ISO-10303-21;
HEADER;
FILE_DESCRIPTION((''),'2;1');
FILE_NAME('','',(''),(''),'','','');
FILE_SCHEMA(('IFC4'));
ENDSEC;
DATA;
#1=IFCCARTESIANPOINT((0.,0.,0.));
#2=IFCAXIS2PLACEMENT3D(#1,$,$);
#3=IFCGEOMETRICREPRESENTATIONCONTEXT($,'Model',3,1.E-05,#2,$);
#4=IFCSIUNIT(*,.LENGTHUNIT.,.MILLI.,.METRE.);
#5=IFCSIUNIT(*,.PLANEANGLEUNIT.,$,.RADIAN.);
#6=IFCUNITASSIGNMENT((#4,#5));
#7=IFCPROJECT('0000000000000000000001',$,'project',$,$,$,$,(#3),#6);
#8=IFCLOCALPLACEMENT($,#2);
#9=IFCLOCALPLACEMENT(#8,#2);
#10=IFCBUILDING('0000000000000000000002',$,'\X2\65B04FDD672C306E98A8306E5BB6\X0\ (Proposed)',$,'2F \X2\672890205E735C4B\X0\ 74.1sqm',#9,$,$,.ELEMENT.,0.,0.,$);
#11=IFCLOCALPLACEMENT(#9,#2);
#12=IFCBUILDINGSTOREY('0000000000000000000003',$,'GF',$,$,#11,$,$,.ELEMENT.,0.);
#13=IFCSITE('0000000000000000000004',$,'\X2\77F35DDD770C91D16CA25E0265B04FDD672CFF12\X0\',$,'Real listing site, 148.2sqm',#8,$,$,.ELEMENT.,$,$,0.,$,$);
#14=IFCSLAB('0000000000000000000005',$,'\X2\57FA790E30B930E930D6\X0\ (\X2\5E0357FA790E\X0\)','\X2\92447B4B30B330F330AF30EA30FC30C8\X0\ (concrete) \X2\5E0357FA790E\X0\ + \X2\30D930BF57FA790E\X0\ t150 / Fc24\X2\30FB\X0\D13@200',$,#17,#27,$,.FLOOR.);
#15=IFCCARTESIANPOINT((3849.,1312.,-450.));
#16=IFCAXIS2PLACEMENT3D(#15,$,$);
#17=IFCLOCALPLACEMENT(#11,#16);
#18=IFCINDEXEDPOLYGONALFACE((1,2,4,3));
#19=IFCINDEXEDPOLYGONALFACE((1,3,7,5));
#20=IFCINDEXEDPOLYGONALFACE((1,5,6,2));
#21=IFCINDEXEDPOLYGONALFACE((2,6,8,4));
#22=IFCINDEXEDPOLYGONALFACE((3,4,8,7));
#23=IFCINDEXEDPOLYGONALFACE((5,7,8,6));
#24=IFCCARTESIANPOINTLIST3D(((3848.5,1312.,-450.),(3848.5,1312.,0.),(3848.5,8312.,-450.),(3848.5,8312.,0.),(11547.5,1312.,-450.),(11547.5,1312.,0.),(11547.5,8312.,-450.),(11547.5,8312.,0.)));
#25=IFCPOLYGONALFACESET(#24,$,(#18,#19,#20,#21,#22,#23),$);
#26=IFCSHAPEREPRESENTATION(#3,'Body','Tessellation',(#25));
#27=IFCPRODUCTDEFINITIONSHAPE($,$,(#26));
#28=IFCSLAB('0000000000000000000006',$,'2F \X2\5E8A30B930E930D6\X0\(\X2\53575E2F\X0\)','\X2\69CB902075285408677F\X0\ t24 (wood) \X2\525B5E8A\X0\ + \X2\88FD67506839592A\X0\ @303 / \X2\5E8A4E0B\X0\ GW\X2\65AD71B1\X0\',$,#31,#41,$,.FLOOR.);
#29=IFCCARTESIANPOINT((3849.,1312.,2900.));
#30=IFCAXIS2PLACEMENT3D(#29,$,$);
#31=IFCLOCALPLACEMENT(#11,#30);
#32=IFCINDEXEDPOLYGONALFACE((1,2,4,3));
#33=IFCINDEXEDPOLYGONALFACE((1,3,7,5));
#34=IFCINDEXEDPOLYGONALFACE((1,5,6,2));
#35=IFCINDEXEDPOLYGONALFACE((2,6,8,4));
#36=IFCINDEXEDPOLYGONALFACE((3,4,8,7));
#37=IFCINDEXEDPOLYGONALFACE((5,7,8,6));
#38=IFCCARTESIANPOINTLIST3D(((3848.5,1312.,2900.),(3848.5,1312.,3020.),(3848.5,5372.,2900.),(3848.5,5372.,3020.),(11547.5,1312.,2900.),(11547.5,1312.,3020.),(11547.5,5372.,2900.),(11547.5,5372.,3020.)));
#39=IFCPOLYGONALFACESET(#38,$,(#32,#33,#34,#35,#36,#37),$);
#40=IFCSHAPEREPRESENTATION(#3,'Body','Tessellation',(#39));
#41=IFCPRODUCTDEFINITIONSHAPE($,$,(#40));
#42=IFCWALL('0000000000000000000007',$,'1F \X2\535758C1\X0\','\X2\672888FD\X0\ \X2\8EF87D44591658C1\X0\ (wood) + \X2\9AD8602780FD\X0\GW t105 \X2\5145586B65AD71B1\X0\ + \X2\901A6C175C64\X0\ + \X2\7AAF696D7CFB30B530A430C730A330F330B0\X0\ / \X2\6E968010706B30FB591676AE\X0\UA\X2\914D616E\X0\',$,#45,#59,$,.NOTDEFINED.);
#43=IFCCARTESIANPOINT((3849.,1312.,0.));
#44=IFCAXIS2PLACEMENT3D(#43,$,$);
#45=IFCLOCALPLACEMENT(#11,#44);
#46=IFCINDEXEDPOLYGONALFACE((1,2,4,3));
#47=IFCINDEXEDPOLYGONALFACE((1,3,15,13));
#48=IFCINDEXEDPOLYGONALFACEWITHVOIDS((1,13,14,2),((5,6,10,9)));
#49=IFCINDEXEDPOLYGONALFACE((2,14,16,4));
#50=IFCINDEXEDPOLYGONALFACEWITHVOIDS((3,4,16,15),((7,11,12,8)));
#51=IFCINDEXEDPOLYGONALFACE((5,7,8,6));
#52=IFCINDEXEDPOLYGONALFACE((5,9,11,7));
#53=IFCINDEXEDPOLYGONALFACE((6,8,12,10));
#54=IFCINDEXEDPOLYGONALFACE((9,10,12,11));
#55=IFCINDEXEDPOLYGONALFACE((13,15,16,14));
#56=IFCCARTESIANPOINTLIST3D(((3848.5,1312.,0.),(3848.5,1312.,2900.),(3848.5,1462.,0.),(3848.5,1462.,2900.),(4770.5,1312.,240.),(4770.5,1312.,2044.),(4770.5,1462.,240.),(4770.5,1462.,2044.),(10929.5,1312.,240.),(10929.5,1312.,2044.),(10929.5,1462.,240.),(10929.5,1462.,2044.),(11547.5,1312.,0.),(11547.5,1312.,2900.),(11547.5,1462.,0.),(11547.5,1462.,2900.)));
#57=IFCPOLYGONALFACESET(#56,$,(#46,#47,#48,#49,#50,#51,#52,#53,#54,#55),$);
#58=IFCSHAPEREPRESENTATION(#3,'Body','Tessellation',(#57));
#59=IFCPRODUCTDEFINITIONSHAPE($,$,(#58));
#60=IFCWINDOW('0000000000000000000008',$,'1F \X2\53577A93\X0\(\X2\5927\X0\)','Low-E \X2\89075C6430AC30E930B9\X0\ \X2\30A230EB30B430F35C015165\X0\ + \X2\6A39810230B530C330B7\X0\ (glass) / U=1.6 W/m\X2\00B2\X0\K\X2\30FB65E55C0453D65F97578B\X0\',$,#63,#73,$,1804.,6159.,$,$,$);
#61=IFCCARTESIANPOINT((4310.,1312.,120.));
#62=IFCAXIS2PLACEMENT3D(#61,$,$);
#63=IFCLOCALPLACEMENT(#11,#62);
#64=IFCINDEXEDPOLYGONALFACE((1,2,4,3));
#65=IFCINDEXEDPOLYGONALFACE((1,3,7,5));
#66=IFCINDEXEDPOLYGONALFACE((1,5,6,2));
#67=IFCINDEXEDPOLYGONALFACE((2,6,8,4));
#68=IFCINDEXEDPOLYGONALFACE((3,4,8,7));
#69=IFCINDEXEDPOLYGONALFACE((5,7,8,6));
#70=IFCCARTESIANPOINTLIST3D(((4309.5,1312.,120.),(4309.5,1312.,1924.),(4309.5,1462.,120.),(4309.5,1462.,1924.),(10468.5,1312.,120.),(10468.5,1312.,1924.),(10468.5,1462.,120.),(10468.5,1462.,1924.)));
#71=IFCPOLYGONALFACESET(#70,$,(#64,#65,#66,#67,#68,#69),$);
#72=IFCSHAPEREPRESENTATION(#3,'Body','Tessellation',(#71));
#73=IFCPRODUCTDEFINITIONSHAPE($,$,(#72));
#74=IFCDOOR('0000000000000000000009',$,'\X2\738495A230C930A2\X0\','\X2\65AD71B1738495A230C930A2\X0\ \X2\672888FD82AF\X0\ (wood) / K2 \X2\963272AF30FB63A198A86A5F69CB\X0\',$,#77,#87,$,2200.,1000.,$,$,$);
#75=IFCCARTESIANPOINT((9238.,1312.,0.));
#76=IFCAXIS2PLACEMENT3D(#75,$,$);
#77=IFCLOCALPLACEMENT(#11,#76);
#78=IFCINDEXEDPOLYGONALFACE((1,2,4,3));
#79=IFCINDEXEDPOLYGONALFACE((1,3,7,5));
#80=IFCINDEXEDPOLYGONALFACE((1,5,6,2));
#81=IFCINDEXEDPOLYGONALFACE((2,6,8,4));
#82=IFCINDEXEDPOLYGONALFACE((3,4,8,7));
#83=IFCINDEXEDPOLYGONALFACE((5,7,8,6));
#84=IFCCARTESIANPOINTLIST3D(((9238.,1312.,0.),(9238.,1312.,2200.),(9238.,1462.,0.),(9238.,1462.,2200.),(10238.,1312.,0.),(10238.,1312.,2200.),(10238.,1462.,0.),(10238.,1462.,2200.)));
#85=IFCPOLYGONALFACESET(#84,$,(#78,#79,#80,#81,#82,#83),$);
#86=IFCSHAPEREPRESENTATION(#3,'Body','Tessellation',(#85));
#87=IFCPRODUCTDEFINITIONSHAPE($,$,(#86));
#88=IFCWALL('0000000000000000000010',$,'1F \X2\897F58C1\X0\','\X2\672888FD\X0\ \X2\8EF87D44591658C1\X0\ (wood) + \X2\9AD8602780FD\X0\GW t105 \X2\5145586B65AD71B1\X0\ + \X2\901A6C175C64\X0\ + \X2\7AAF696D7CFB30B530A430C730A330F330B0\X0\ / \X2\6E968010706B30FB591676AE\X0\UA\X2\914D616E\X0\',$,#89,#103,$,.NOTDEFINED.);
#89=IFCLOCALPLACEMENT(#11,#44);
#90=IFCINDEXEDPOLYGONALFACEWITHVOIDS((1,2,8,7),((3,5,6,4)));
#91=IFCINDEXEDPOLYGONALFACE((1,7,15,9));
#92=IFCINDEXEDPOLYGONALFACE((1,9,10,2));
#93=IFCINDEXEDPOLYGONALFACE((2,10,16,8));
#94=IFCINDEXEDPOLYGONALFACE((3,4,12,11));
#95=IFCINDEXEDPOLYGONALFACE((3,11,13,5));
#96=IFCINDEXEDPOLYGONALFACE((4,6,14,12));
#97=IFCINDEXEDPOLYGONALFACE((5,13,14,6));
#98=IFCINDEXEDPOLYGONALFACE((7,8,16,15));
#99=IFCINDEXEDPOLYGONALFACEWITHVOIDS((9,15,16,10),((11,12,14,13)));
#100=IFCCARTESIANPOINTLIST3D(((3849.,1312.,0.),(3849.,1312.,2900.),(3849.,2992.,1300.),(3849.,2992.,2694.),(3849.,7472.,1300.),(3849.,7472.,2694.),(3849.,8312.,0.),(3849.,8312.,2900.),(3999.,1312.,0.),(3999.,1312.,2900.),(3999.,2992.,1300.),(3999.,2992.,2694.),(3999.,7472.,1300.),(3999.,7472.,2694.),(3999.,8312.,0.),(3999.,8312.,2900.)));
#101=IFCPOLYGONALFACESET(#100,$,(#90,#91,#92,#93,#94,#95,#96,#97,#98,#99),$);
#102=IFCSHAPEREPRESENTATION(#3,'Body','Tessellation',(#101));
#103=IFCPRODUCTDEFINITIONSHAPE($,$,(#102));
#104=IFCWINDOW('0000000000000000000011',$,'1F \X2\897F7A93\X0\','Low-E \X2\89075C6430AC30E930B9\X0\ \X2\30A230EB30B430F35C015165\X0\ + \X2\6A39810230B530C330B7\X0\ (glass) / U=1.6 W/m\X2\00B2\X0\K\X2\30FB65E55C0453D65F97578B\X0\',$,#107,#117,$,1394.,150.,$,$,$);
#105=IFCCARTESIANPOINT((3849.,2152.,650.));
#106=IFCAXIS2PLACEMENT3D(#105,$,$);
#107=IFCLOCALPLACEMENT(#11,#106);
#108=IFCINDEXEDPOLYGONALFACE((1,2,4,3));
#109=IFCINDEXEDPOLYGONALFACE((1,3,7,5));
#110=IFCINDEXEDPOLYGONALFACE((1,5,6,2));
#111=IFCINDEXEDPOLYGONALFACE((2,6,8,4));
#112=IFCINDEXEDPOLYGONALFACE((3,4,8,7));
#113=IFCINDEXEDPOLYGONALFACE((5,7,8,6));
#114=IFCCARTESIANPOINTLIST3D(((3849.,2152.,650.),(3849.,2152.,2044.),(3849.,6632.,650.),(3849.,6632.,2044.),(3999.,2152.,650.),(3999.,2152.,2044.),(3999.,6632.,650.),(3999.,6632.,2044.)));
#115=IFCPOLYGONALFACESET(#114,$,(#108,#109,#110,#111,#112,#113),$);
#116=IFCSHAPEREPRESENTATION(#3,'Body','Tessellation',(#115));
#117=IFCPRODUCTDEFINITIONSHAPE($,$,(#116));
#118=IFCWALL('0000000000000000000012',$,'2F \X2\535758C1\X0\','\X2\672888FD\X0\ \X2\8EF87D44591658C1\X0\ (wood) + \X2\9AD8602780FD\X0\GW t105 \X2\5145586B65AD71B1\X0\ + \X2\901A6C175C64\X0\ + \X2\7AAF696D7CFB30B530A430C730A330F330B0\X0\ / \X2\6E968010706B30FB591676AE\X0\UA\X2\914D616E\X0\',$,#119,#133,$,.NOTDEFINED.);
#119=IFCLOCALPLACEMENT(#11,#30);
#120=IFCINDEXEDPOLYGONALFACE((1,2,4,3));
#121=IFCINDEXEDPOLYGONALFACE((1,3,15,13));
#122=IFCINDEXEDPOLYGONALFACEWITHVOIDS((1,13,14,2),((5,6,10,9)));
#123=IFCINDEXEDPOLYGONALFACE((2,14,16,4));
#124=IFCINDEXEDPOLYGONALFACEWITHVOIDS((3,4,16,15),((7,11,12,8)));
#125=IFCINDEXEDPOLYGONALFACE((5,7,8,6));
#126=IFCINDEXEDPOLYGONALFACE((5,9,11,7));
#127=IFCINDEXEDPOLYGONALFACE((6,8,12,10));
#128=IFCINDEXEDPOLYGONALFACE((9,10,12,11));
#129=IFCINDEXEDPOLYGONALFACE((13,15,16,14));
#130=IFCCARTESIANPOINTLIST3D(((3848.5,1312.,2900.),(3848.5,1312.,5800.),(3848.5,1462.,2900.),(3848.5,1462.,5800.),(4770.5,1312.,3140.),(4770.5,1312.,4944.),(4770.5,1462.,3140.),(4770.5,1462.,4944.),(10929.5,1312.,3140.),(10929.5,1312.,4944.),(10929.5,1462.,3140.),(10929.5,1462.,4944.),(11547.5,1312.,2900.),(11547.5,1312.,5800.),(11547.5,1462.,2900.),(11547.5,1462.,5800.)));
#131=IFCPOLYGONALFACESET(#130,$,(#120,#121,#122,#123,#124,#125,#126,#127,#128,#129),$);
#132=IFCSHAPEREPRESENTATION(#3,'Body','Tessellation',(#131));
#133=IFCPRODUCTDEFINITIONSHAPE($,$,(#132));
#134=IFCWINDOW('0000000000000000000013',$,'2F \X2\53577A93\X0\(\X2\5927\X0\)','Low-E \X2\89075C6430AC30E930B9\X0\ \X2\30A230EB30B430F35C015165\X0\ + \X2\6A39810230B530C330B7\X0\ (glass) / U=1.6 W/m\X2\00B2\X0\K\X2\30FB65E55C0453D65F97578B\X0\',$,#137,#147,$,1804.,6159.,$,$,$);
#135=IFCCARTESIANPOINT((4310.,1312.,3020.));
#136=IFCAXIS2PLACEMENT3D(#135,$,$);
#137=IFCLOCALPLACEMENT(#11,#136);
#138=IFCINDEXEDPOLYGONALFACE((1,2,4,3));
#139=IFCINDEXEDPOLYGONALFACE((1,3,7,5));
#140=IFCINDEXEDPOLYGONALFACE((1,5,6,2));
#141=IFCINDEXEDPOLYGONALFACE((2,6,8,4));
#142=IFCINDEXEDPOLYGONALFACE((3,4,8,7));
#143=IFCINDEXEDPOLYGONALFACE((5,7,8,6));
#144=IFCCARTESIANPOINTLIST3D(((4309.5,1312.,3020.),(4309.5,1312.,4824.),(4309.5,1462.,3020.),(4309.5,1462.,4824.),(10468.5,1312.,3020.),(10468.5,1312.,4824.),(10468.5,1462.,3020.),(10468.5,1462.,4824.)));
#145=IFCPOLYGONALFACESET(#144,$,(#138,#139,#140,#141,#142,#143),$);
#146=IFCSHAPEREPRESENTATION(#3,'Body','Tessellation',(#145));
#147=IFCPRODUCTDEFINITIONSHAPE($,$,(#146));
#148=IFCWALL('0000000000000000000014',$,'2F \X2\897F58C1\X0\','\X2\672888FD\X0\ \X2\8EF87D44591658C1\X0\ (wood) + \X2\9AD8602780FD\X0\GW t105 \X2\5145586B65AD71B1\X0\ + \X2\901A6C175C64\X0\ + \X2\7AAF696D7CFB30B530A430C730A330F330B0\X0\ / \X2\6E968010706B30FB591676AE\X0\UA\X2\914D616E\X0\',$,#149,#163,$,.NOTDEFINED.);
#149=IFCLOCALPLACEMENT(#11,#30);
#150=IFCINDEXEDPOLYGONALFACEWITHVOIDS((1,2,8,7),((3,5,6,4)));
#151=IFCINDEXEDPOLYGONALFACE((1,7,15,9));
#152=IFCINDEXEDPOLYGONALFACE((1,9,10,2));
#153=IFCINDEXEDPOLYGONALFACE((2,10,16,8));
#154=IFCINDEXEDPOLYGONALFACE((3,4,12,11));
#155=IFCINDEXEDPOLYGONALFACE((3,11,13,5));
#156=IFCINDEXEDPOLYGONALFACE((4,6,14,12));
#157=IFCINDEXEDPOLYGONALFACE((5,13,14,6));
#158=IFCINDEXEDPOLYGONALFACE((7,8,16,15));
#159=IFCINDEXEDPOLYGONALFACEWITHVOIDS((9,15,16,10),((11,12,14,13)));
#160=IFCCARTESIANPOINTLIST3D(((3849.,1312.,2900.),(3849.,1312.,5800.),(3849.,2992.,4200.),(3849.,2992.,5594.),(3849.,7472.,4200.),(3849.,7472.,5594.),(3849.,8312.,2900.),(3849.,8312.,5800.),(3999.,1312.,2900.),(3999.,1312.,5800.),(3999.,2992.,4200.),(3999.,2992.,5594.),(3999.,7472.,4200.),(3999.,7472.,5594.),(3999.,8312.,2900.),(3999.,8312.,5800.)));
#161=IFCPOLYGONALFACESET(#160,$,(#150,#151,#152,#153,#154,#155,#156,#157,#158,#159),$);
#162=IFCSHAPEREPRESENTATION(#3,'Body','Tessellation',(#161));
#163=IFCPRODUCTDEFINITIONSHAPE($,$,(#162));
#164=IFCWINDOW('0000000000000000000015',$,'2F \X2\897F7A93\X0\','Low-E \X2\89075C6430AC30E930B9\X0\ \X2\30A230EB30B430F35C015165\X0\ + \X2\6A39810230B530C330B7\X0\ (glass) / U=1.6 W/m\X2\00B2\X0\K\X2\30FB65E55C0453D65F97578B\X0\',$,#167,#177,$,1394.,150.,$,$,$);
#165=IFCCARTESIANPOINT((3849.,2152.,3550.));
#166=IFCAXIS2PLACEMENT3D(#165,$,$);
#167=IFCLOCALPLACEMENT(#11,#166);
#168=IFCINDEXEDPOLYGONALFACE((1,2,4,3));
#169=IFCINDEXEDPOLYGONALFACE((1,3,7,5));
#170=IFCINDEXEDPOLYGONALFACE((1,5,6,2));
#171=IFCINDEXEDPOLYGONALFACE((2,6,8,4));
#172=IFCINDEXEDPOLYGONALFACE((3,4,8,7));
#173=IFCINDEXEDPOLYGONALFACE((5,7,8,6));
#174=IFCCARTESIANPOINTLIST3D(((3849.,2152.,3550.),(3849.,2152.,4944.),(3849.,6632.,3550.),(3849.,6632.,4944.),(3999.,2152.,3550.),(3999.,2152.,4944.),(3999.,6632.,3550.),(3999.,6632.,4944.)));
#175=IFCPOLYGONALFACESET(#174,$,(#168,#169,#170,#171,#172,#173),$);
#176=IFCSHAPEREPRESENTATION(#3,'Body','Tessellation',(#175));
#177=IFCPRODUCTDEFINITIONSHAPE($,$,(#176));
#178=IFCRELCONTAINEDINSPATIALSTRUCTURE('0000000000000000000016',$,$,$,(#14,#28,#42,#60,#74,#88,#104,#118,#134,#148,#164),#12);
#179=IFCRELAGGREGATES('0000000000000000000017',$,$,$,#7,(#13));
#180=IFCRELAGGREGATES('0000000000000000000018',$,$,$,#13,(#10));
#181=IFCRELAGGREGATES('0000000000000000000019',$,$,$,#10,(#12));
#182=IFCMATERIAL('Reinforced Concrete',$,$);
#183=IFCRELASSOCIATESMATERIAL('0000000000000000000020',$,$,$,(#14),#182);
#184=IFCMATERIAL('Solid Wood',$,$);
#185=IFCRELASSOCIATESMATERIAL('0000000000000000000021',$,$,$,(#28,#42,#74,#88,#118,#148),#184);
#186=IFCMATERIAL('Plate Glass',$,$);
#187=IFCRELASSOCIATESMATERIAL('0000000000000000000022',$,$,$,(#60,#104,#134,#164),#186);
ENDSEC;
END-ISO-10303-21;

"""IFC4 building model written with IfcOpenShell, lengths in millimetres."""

from ifc_helpers import new_model, si_unit, frame, frame_2d, origin, place, context, project, spatial, rectangle, extrude, material, element, fill, save


model = new_model("IFC4")

# Units and contexts
model_context = context("Model", 3, precision=1e-05, world=origin())
ifc_project = project(units=[si_unit("LENGTHUNIT", "METRE", prefix="MILLI"), si_unit("PLANEANGLEUNIT", "RADIAN")], contexts=[model_context])

# Site, building, storey
site_placement = place(None, origin())
site = spatial("IfcSite", under=ifc_project, at=site_placement, Name="石川県金沢市新保本２", ObjectType="Real listing site, 148.2sqm", CompositionType="ELEMENT", RefElevation=0.0)
building_placement = place(site_placement, origin())
building = spatial("IfcBuilding", under=site, at=building_placement, Name="新保本の風の家 (Proposed)", ObjectType="2F 木造平屋 74.1sqm", CompositionType="ELEMENT", ElevationOfRefHeight=0.0, ElevationOfTerrain=0.0)
storey_placement = place(building_placement, origin())
storey = spatial("IfcBuildingStorey", under=building, at=storey_placement, Name="GF", CompositionType="ELEMENT", Elevation=0.0)

# Slabs
ifc_material_1 = material(Name="Reinforced Concrete")
slab_1_placement = place(storey_placement, frame((3849.0, 1312.0, -450.0)))
element("IfcSlab", 1, at=slab_1_placement, inside=storey, material=ifc_material_1, Name="基礎スラブ (布基礎)", Description="鉄筋コンクリート (concrete) 布基礎 + ベタ基礎 t150 / Fc24・D13@200", PredefinedType="FLOOR", context=model_context, shape_type="SweptSolid", body=[
    extrude(rectangle(XDim=7699.0, YDim=7000.0, at=frame_2d((3849.0, 3500.0))), frame((3849.0, 1312.0, -450.0)), (0.0, 0.0, 1.0), 450.0),
])
ifc_material_2 = material(Name="Solid Wood")
slab_2_placement = place(storey_placement, frame((3849.0, 1312.0, 2900.0)))
element("IfcSlab", 2, at=slab_2_placement, inside=storey, material=ifc_material_2, Name="2F 床スラブ(南帯)", Description="構造用合板 t24 (wood) 剛床 + 製材根太 @303 / 床下 GW断熱", PredefinedType="FLOOR", context=model_context, shape_type="SweptSolid", body=[
    extrude(rectangle(XDim=7699.0, YDim=4060.0, at=frame_2d((3849.0, 2030.0))), frame((3849.0, 1312.0, 2900.0)), (0.0, 0.0, 1.0), 120.0),
])

# Wall, openings, window, door
wall_1_placement = place(storey_placement, frame((3849.0, 1312.0, 0.0)))
wall_1 = element("IfcWall", 3, at=wall_1_placement, inside=storey, material=ifc_material_2, Name="1F 南壁", Description="木製 軸組外壁 (wood) + 高性能GW t105 充填断熱 + 通気層 + 窯業系サイディング / 準耐火・外皮UA配慮", PredefinedType="NOTDEFINED", context=model_context, shape_type="SweptSolid", body=[
    extrude(rectangle(XDim=7699.0, YDim=150.0, at=frame_2d((3849.0, 75.0))), frame((3849.0, 1312.0, 0.0)), (0.0, 0.0, 1.0), 2900.0),
])
opening_1_placement = place(storey_placement, frame((4310.0, 1312.0, 120.0)))
opening_1 = element("IfcOpeningElement", 4, at=opening_1_placement, cuts=wall_1, PredefinedType="NOTDEFINED", context=model_context, shape_type="SweptSolid", body=[
    extrude(rectangle(XDim=6159.0, YDim=150.0, at=frame_2d((3079.0, 75.0))), frame((4310.0, 1312.0, 120.0)), (0.0, 0.0, 1.0), 1804.0),
])
opening_2_placement = place(storey_placement, frame((9238.0, 1312.0, 0.0)))
opening_2 = element("IfcOpeningElement", 5, at=opening_2_placement, cuts=wall_1, PredefinedType="NOTDEFINED", context=model_context, shape_type="SweptSolid", body=[
    extrude(rectangle(XDim=1000.0, YDim=150.0, at=frame_2d((500.0, 75.0))), frame((9238.0, 1312.0, 0.0)), (0.0, 0.0, 1.0), 2200.0),
])
ifc_material_3 = material(Name="Plate Glass")
window_1_placement = place(storey_placement, frame((4310.0, 1312.0, 120.0)))
window_1 = element("IfcWindow", 6, at=window_1_placement, inside=storey, material=ifc_material_3, Name="1F 南窓(大)", Description="Low-E 複層ガラス アルゴン封入 + 樹脂サッシ (glass) / U=1.6 W/m²K・日射取得型", OverallHeight=1804.0, OverallWidth=6159.0, context=model_context, shape_type="SweptSolid", body=[
    extrude(rectangle(XDim=6159.0, YDim=150.0, at=frame_2d((3079.0, 75.0))), frame((4310.0, 1312.0, 120.0)), (0.0, 0.0, 1.0), 1804.0),
])
fill(opening_1, window_1)
door_placement = place(storey_placement, frame((9238.0, 1312.0, 0.0)))
door = element("IfcDoor", 7, at=door_placement, inside=storey, material=ifc_material_2, Name="玄関ドア", Description="断熱玄関ドア 木製芯 (wood) / K2 防犯・採風機構", OverallHeight=2200.0, OverallWidth=1000.0, context=model_context, shape_type="SweptSolid", body=[
    extrude(rectangle(XDim=1000.0, YDim=150.0, at=frame_2d((500.0, 75.0))), frame((9238.0, 1312.0, 0.0)), (0.0, 0.0, 1.0), 2200.0),
])
fill(opening_2, door)

# Wall, opening, window
wall_2_placement = place(storey_placement, frame((3849.0, 1312.0, 0.0)))
wall_2 = element("IfcWall", 8, at=wall_2_placement, inside=storey, material=ifc_material_2, Name="1F 西壁", Description="木製 軸組外壁 (wood) + 高性能GW t105 充填断熱 + 通気層 + 窯業系サイディング / 準耐火・外皮UA配慮", PredefinedType="NOTDEFINED", context=model_context, shape_type="SweptSolid", body=[
    extrude(rectangle(XDim=150.0, YDim=7000.0, at=frame_2d((75.0, 3500.0))), frame((3849.0, 1312.0, 0.0)), (0.0, 0.0, 1.0), 2900.0),
])
opening_3_placement = place(storey_placement, frame((3849.0, 2152.0, 650.0)))
opening_3 = element("IfcOpeningElement", 9, at=opening_3_placement, cuts=wall_2, PredefinedType="NOTDEFINED", context=model_context, shape_type="SweptSolid", body=[
    extrude(rectangle(XDim=150.0, YDim=4480.0, at=frame_2d((75.0, 2240.0))), frame((3849.0, 2152.0, 650.0)), (0.0, 0.0, 1.0), 1394.0),
])
window_2_placement = place(storey_placement, frame((3849.0, 2152.0, 650.0)))
window_2 = element("IfcWindow", 10, at=window_2_placement, inside=storey, material=ifc_material_3, Name="1F 西窓", Description="Low-E 複層ガラス アルゴン封入 + 樹脂サッシ (glass) / U=1.6 W/m²K・日射取得型", OverallHeight=1394.0, OverallWidth=150.0, context=model_context, shape_type="SweptSolid", body=[
    extrude(rectangle(XDim=150.0, YDim=4480.0, at=frame_2d((75.0, 2240.0))), frame((3849.0, 2152.0, 650.0)), (0.0, 0.0, 1.0), 1394.0),
])
fill(opening_3, window_2)

# Walls, openings, windows
wall_3_placement = place(storey_placement, frame((3849.0, 1312.0, 2900.0)))
wall_3 = element("IfcWall", 11, at=wall_3_placement, inside=storey, material=ifc_material_2, Name="2F 南壁", Description="木製 軸組外壁 (wood) + 高性能GW t105 充填断熱 + 通気層 + 窯業系サイディング / 準耐火・外皮UA配慮", PredefinedType="NOTDEFINED", context=model_context, shape_type="SweptSolid", body=[
    extrude(rectangle(XDim=7699.0, YDim=150.0, at=frame_2d((3849.0, 75.0))), frame((3849.0, 1312.0, 2900.0)), (0.0, 0.0, 1.0), 2900.0),
])
opening_4_placement = place(storey_placement, frame((4310.0, 1312.0, 3020.0)))
opening_4 = element("IfcOpeningElement", 12, at=opening_4_placement, cuts=wall_3, PredefinedType="NOTDEFINED", context=model_context, shape_type="SweptSolid", body=[
    extrude(rectangle(XDim=6159.0, YDim=150.0, at=frame_2d((3079.0, 75.0))), frame((4310.0, 1312.0, 3020.0)), (0.0, 0.0, 1.0), 1804.0),
])
window_3_placement = place(storey_placement, frame((4310.0, 1312.0, 3020.0)))
window_3 = element("IfcWindow", 13, at=window_3_placement, inside=storey, material=ifc_material_3, Name="2F 南窓(大)", Description="Low-E 複層ガラス アルゴン封入 + 樹脂サッシ (glass) / U=1.6 W/m²K・日射取得型", OverallHeight=1804.0, OverallWidth=6159.0, context=model_context, shape_type="SweptSolid", body=[
    extrude(rectangle(XDim=6159.0, YDim=150.0, at=frame_2d((3079.0, 75.0))), frame((4310.0, 1312.0, 3020.0)), (0.0, 0.0, 1.0), 1804.0),
])
fill(opening_4, window_3)
wall_4_placement = place(storey_placement, frame((3849.0, 1312.0, 2900.0)))
wall_4 = element("IfcWall", 14, at=wall_4_placement, inside=storey, material=ifc_material_2, Name="2F 西壁", Description="木製 軸組外壁 (wood) + 高性能GW t105 充填断熱 + 通気層 + 窯業系サイディング / 準耐火・外皮UA配慮", PredefinedType="NOTDEFINED", context=model_context, shape_type="SweptSolid", body=[
    extrude(rectangle(XDim=150.0, YDim=7000.0, at=frame_2d((75.0, 3500.0))), frame((3849.0, 1312.0, 2900.0)), (0.0, 0.0, 1.0), 2900.0),
])
opening_5_placement = place(storey_placement, frame((3849.0, 2152.0, 3550.0)))
opening_5 = element("IfcOpeningElement", 15, at=opening_5_placement, cuts=wall_4, PredefinedType="NOTDEFINED", context=model_context, shape_type="SweptSolid", body=[
    extrude(rectangle(XDim=150.0, YDim=4480.0, at=frame_2d((75.0, 2240.0))), frame((3849.0, 2152.0, 3550.0)), (0.0, 0.0, 1.0), 1394.0),
])
window_4_placement = place(storey_placement, frame((3849.0, 2152.0, 3550.0)))
window_4 = element("IfcWindow", 16, at=window_4_placement, inside=storey, material=ifc_material_3, Name="2F 西窓", Description="Low-E 複層ガラス アルゴン封入 + 樹脂サッシ (glass) / U=1.6 W/m²K・日射取得型", OverallHeight=1394.0, OverallWidth=150.0, context=model_context, shape_type="SweptSolid", body=[
    extrude(rectangle(XDim=150.0, YDim=4480.0, at=frame_2d((75.0, 2240.0))), frame((3849.0, 2152.0, 3550.0)), (0.0, 0.0, 1.0), 1394.0),
])
fill(opening_5, window_4)

save(model, "model.ifc")
